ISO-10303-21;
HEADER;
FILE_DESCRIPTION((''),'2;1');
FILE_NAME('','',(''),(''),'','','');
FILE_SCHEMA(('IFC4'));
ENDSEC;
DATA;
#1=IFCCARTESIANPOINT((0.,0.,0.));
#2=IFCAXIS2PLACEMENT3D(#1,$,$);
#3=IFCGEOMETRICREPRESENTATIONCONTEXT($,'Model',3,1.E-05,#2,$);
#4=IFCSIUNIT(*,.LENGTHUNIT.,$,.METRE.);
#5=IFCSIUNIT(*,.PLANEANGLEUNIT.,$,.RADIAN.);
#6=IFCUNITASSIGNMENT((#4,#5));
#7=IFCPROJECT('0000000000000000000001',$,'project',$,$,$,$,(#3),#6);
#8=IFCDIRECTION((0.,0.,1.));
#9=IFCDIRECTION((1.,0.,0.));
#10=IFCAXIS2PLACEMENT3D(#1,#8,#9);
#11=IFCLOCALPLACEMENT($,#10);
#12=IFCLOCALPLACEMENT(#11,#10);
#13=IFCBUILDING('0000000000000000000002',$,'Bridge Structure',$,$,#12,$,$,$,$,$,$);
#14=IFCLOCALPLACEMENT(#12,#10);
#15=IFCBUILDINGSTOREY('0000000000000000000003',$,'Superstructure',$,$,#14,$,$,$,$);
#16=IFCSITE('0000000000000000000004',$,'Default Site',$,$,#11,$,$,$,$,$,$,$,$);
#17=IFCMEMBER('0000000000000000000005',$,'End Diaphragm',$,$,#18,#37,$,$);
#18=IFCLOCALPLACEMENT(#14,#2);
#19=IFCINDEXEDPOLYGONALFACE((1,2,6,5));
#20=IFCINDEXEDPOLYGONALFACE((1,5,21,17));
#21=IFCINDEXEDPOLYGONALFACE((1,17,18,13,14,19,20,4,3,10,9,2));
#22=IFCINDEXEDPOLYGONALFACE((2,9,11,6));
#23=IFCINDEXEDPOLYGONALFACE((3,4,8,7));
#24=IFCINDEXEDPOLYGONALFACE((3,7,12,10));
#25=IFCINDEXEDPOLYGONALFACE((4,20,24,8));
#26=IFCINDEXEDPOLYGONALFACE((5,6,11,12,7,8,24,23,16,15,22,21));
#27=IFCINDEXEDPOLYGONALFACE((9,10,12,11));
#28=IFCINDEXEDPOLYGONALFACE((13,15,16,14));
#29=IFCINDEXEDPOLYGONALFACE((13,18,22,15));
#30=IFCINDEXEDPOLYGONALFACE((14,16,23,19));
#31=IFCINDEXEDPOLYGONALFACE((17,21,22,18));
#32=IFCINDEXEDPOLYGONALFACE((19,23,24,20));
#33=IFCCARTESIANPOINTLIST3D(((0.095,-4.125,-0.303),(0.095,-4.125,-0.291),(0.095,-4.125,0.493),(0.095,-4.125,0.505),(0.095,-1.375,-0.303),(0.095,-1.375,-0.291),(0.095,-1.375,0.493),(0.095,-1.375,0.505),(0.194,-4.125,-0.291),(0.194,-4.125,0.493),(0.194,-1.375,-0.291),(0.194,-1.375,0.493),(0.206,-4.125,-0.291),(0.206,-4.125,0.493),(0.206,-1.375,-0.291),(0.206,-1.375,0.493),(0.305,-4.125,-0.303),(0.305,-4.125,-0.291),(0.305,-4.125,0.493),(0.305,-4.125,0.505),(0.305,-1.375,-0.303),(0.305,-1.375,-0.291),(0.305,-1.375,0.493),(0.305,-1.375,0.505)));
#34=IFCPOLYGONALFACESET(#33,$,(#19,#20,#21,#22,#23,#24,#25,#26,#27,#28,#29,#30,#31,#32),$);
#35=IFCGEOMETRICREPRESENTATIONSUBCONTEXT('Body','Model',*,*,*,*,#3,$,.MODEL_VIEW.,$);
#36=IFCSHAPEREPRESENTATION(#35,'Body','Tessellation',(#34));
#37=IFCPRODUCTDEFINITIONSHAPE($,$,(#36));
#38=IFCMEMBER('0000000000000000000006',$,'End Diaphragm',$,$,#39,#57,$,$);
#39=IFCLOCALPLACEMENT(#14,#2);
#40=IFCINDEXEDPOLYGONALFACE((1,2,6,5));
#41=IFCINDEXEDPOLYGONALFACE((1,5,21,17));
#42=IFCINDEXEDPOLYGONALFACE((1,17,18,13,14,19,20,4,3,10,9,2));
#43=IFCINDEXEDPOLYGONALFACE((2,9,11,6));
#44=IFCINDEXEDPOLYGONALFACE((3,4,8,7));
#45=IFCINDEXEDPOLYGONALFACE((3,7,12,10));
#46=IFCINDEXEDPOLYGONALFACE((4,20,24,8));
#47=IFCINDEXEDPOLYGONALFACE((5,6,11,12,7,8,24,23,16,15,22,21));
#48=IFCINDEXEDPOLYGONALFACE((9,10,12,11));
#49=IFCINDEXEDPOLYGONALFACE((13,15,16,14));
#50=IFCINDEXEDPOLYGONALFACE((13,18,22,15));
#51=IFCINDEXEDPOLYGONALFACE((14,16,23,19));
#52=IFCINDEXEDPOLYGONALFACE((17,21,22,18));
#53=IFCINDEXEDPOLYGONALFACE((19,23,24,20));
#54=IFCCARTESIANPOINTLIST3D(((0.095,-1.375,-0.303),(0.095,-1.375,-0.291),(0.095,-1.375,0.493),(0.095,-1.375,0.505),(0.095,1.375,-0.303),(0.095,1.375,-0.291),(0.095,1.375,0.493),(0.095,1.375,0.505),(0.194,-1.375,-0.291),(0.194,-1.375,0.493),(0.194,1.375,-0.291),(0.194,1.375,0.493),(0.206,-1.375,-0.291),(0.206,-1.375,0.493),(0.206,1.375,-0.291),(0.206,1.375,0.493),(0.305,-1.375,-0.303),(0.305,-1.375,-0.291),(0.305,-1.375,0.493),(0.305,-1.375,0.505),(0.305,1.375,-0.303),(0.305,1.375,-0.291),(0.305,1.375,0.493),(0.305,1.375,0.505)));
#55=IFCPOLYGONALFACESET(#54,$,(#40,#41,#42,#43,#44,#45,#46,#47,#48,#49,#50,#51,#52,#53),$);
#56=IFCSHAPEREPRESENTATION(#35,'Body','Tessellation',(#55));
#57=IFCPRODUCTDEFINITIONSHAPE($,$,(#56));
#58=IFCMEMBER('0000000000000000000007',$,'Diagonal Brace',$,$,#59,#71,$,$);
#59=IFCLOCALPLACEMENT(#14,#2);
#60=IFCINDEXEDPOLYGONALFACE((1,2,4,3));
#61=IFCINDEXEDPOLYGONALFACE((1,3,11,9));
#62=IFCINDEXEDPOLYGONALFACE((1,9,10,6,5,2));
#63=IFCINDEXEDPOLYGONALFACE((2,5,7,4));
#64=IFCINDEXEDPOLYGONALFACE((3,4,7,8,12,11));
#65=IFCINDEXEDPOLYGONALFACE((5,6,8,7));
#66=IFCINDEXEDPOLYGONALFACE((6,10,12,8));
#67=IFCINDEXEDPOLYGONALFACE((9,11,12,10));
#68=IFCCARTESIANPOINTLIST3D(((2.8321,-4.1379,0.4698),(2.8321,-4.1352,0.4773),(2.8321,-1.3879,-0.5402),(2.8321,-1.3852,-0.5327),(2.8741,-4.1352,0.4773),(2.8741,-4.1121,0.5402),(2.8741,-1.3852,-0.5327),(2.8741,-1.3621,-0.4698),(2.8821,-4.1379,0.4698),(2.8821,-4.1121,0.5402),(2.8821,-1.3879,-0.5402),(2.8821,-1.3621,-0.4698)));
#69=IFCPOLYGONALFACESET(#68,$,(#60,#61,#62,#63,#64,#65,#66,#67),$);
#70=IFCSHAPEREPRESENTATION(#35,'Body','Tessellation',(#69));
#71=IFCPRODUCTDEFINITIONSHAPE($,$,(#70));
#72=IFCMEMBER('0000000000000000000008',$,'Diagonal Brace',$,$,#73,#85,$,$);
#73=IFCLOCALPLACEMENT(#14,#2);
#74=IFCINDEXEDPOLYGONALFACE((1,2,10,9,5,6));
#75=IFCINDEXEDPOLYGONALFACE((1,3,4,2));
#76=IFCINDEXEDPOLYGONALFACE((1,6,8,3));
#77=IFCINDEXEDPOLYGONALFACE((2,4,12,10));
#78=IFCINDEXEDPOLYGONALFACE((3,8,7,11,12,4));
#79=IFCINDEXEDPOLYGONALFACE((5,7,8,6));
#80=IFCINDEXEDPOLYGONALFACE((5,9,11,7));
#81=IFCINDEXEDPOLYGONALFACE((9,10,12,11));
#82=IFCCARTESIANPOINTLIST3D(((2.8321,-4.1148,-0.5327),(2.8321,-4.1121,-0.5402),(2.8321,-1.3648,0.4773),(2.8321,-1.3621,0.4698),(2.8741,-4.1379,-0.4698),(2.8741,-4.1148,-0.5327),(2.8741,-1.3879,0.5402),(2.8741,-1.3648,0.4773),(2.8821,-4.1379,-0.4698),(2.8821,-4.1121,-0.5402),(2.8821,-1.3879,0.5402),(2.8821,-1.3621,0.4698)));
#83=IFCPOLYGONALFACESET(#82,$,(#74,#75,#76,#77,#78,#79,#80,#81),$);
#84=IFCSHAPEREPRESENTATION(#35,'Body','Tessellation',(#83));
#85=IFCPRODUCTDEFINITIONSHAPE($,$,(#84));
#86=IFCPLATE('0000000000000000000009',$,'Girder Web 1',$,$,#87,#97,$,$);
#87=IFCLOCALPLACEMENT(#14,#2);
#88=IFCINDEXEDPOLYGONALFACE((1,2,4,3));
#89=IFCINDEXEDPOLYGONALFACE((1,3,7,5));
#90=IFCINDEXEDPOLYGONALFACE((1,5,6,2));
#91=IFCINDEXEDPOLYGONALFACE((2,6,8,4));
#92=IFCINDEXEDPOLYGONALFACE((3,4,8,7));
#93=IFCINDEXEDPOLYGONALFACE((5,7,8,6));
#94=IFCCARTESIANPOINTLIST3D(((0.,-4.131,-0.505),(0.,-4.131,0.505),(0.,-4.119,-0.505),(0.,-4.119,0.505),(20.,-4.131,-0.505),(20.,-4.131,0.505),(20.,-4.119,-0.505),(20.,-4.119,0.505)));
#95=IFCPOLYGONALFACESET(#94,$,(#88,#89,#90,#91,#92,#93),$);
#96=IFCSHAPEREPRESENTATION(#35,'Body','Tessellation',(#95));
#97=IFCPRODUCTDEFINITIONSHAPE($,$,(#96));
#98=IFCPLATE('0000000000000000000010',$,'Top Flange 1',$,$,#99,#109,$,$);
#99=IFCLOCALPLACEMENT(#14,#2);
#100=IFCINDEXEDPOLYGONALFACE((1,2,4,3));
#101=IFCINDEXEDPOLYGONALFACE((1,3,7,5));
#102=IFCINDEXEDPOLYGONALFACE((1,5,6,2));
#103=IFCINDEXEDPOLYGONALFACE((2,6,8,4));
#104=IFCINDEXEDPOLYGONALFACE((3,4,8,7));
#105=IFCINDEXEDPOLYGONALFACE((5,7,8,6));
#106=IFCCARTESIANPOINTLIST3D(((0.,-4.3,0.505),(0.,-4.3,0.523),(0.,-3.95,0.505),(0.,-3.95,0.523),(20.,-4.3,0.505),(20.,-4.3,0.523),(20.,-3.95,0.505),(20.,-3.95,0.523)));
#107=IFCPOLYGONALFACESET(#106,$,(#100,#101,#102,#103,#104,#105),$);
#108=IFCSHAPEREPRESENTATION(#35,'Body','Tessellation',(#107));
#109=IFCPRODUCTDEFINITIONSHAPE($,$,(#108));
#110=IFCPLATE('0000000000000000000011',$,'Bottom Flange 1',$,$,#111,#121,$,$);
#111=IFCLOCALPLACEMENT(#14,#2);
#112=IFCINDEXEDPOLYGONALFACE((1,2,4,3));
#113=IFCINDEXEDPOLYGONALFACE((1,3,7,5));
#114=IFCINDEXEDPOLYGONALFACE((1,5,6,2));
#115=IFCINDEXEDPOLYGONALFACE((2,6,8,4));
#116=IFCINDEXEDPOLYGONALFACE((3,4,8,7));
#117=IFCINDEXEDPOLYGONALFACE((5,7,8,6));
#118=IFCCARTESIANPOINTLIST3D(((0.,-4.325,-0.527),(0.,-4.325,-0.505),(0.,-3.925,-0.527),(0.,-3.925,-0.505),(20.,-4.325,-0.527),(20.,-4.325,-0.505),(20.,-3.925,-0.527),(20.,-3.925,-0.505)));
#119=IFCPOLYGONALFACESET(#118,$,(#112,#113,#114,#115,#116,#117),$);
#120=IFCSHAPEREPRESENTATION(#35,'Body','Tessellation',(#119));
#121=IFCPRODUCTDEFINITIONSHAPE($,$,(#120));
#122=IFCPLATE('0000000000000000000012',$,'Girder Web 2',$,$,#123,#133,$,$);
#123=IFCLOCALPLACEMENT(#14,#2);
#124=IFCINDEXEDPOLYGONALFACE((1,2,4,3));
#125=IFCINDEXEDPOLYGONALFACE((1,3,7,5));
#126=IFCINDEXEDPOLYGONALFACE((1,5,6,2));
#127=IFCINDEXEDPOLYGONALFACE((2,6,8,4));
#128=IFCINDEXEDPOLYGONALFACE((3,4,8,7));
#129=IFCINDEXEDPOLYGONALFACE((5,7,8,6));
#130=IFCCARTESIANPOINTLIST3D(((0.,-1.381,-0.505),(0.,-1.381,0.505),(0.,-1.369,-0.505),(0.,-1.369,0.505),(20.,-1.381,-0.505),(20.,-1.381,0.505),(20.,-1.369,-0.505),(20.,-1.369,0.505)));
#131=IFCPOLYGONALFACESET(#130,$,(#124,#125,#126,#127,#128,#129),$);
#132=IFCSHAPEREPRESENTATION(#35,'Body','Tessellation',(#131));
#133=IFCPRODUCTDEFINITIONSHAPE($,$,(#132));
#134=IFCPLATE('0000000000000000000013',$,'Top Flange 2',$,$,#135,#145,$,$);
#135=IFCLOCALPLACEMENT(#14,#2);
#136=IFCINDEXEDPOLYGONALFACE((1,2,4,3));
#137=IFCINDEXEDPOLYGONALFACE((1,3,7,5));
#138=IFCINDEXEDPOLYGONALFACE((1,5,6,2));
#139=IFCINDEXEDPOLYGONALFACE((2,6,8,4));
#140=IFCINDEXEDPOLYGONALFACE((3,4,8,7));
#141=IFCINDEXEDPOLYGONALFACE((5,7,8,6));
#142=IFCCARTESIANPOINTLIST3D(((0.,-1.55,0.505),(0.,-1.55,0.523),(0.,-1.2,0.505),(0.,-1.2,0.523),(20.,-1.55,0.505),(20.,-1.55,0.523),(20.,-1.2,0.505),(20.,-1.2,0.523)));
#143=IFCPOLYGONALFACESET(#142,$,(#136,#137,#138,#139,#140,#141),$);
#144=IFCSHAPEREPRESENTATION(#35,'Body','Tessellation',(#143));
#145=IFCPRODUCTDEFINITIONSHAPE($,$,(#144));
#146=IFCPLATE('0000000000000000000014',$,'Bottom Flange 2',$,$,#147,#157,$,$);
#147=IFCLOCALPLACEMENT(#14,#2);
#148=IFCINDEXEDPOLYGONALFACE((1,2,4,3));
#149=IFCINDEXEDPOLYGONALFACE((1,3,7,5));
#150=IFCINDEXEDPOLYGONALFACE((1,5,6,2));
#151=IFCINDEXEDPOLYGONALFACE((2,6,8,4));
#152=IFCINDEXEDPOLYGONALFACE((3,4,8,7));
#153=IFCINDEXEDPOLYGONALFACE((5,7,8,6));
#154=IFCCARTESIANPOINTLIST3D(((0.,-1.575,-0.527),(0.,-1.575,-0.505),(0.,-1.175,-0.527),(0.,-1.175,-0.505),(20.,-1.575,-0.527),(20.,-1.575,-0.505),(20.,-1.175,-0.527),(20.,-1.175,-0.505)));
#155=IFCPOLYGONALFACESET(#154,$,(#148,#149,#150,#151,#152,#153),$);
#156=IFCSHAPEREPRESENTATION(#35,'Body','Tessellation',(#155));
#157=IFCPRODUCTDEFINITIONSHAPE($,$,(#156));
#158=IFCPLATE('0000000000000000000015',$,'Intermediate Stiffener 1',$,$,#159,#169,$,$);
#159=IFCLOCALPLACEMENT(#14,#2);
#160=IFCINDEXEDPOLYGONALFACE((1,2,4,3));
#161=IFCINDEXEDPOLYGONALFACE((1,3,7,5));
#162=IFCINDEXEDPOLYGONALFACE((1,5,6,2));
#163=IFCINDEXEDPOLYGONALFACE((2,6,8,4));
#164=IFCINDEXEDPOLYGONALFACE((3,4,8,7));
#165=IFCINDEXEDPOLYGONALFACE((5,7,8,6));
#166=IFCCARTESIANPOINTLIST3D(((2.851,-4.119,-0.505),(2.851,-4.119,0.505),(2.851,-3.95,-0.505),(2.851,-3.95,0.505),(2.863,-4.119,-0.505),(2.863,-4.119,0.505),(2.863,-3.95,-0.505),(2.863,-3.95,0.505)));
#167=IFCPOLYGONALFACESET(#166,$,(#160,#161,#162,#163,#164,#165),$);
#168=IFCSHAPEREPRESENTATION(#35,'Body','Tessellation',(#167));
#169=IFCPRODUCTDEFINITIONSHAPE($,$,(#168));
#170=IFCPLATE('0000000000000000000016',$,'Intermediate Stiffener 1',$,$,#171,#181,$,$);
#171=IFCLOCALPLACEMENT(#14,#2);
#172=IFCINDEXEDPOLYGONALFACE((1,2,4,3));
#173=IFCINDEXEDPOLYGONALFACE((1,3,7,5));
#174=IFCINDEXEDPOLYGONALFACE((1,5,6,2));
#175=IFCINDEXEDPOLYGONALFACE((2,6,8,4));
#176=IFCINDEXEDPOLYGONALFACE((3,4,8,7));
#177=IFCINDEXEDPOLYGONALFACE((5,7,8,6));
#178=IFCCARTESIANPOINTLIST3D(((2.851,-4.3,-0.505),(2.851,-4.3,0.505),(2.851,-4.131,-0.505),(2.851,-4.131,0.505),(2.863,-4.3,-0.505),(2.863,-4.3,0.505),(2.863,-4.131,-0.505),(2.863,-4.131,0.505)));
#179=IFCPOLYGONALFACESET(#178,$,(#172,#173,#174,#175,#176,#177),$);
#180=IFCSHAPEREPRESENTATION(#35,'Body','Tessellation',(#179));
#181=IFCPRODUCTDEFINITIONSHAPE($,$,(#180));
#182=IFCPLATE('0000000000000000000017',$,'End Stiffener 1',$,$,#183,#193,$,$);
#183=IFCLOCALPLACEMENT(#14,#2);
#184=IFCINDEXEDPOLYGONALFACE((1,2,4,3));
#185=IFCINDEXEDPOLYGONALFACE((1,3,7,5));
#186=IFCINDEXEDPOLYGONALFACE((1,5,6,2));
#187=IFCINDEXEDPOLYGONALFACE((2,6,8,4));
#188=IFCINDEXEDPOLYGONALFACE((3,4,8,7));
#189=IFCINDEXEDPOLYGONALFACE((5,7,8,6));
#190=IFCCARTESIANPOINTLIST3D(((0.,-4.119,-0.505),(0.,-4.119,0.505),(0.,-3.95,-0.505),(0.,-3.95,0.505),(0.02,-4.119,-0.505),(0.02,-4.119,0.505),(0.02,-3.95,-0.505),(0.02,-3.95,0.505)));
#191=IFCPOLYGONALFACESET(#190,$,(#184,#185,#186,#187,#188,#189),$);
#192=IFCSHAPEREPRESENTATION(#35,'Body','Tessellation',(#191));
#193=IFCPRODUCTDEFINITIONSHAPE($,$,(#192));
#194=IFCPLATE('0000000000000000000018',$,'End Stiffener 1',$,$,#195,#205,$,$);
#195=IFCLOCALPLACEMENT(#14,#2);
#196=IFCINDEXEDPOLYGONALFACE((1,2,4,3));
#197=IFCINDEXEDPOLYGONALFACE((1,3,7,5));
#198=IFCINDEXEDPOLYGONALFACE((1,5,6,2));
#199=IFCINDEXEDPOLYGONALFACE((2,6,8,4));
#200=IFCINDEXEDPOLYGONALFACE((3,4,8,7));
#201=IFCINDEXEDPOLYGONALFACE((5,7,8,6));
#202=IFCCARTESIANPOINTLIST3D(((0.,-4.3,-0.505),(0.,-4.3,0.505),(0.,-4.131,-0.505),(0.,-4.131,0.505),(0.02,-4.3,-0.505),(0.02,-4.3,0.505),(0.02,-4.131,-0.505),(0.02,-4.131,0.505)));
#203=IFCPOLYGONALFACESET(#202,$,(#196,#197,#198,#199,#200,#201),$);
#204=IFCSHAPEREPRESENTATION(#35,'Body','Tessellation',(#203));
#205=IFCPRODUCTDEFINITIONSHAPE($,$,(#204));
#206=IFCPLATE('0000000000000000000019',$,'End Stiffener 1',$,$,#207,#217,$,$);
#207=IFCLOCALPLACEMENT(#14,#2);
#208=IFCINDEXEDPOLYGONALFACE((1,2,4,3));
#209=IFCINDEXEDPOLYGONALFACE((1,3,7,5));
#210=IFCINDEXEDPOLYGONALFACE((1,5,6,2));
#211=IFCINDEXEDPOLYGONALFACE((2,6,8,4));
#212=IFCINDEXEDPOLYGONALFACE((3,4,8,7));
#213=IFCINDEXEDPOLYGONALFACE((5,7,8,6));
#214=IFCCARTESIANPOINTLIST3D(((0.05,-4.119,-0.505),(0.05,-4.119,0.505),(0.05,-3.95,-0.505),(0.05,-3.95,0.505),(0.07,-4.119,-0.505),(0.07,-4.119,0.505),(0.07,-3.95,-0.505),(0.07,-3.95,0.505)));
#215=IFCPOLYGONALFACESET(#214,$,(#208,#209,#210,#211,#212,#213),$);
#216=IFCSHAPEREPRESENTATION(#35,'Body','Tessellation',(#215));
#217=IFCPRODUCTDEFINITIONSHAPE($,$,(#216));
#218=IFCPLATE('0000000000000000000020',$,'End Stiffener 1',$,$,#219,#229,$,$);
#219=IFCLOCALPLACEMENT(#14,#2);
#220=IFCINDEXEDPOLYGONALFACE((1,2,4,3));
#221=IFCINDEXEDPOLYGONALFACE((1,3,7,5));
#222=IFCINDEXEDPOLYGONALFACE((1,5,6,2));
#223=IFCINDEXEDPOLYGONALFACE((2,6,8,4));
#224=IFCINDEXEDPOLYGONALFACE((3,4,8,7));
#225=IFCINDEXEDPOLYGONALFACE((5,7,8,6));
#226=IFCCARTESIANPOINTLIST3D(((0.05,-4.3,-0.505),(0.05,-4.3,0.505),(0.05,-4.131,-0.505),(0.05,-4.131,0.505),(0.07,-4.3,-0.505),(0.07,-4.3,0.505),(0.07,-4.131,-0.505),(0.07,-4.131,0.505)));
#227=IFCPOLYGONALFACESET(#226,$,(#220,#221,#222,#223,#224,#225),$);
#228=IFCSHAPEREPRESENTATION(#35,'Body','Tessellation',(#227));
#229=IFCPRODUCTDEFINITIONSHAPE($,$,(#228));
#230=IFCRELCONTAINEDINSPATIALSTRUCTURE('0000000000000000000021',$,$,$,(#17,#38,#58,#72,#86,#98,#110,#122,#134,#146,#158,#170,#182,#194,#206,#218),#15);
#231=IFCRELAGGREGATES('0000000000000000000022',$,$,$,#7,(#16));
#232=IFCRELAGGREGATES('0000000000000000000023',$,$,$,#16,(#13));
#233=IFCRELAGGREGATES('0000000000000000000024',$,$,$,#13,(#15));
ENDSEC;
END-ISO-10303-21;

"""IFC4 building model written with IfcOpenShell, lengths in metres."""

from ifc_helpers import new_model, si_unit, frame, origin, origin_with_axes, origin_2d_with_axis, place, context, subcontext, project, spatial, rectangle, i_section, l_section, extrude, element, save


model = new_model("IFC4")

# Units and contexts
model_context = context("Model", 3, precision=1e-05, world=origin())
body_context = subcontext(model_context, "Body", "Model", "MODEL_VIEW")
ifc_project = project(units=[si_unit("LENGTHUNIT", "METRE"), si_unit("PLANEANGLEUNIT", "RADIAN")], contexts=[model_context])

# Site, building, storey
site_placement = place(None, origin_with_axes())
site = spatial("IfcSite", under=ifc_project, at=site_placement, Name="Default Site")
building_placement = place(site_placement, origin_with_axes())
building = spatial("IfcBuilding", under=site, at=building_placement, Name="Bridge Structure")
storey_placement = place(building_placement, origin_with_axes())
storey = spatial("IfcBuildingStorey", under=building, at=storey_placement, Name="Superstructure")

# Members
for number, where, z_axis, x_axis, name in (
    (1, (0.2, -4.125, 0.101), (0.0, 1.0, 0.0), (-1.0, 0.0, 0.0), "End Diaphragm"),
    (2, (0.2, -1.375, 0.101), (0.0, 1.0, 0.0), (-1.0, 0.0, 0.0), "End Diaphragm"),
):
    element("IfcMember", number, at=place(storey_placement, frame(where, z_axis=z_axis, x_axis=x_axis)), inside=storey, Name=name, context=body_context, shape_type="SweptSolid", body=[
        extrude(i_section(OverallWidth=0.21, OverallDepth=0.808, WebThickness=0.012, FlangeThickness=0.012, at=origin_2d_with_axis()), origin_with_axes(), (0.0, 0.0, 1.0), 2.75),
    ])
for number, where, z_axis, x_axis, name in (
    (3, (2.8571, -4.125, 0.505), (0.0, 0.938692, -0.344756), (-1.0, 0.0, 0.0), "Diagonal Brace"),
    (4, (2.8571, -4.125, -0.505), (0.0, 0.938692, 0.344756), (-1.0, 0.0, 0.0), "Diagonal Brace"),
):
    element("IfcMember", number, at=place(storey_placement, frame(where, z_axis=z_axis, x_axis=x_axis)), inside=storey, Name=name, context=body_context, shape_type="SweptSolid", body=[
        extrude(l_section(Depth=0.075, Width=0.05, Thickness=0.008, at=origin_2d_with_axis()), origin_with_axes(), (0.0, 0.0, 1.0), 2.9296),
    ])

# Plates
plate_1_placement = place(storey_placement, frame((0.0, -4.125, 0.0), z_axis=(1.0, 0.0, 0.0), x_axis=(0.0, 1.0, 0.0)))
element("IfcPlate", 5, at=plate_1_placement, inside=storey, Name="Girder Web 1", context=body_context, shape_type="SweptSolid", body=[
    extrude(rectangle(XDim=0.012, YDim=1.01, at=origin_2d_with_axis()), origin_with_axes(), (0.0, 0.0, 1.0), 20.0),
])
plate_2_placement = place(storey_placement, frame((0.0, -4.125, 0.514), z_axis=(1.0, 0.0, 0.0), x_axis=(0.0, 1.0, 0.0)))
element("IfcPlate", 6, at=plate_2_placement, inside=storey, Name="Top Flange 1", context=body_context, shape_type="SweptSolid", body=[
    extrude(rectangle(XDim=0.35, YDim=0.018, at=origin_2d_with_axis()), origin_with_axes(), (0.0, 0.0, 1.0), 20.0),
])
plate_3_placement = place(storey_placement, frame((0.0, -4.125, -0.516), z_axis=(1.0, 0.0, 0.0), x_axis=(0.0, 1.0, 0.0)))
element("IfcPlate", 7, at=plate_3_placement, inside=storey, Name="Bottom Flange 1", context=body_context, shape_type="SweptSolid", body=[
    extrude(rectangle(XDim=0.4, YDim=0.022, at=origin_2d_with_axis()), origin_with_axes(), (0.0, 0.0, 1.0), 20.0),
])
plate_4_placement = place(storey_placement, frame((0.0, -1.375, 0.0), z_axis=(1.0, 0.0, 0.0), x_axis=(0.0, 1.0, 0.0)))
element("IfcPlate", 8, at=plate_4_placement, inside=storey, Name="Girder Web 2", context=body_context, shape_type="SweptSolid", body=[
    extrude(rectangle(XDim=0.012, YDim=1.01, at=origin_2d_with_axis()), origin_with_axes(), (0.0, 0.0, 1.0), 20.0),
])
plate_5_placement = place(storey_placement, frame((0.0, -1.375, 0.514), z_axis=(1.0, 0.0, 0.0), x_axis=(0.0, 1.0, 0.0)))
element("IfcPlate", 9, at=plate_5_placement, inside=storey, Name="Top Flange 2", context=body_context, shape_type="SweptSolid", body=[
    extrude(rectangle(XDim=0.35, YDim=0.018, at=origin_2d_with_axis()), origin_with_axes(), (0.0, 0.0, 1.0), 20.0),
])
plate_6_placement = place(storey_placement, frame((0.0, -1.375, -0.516), z_axis=(1.0, 0.0, 0.0), x_axis=(0.0, 1.0, 0.0)))
element("IfcPlate", 10, at=plate_6_placement, inside=storey, Name="Bottom Flange 2", context=body_context, shape_type="SweptSolid", body=[
    extrude(rectangle(XDim=0.4, YDim=0.022, at=origin_2d_with_axis()), origin_with_axes(), (0.0, 0.0, 1.0), 20.0),
])
for number, where, z_axis, x_axis, name in (
    (11, (2.857, -4.0345, -0.505), (0.0, 0.0, 1.0), (1.0, 0.0, 0.0), "Intermediate Stiffener 1"),
    (12, (2.857, -4.2155, -0.505), (0.0, 0.0, 1.0), (1.0, 0.0, 0.0), "Intermediate Stiffener 1"),
):
    element("IfcPlate", number, at=place(storey_placement, frame(where, z_axis=z_axis, x_axis=x_axis)), inside=storey, Name=name, context=body_context, shape_type="SweptSolid", body=[
        extrude(rectangle(XDim=0.012, YDim=0.169, at=origin_2d_with_axis()), origin_with_axes(), (0.0, 0.0, 1.0), 1.01),
    ])
for number, where, z_axis, x_axis, name in (
    (13, (0.01, -4.0345, -0.505), (0.0, 0.0, 1.0), (1.0, 0.0, 0.0), "End Stiffener 1"),
    (14, (0.01, -4.2155, -0.505), (0.0, 0.0, 1.0), (1.0, 0.0, 0.0), "End Stiffener 1"),
    (15, (0.06, -4.0345, -0.505), (0.0, 0.0, 1.0), (1.0, 0.0, 0.0), "End Stiffener 1"),
    (16, (0.06, -4.2155, -0.505), (0.0, 0.0, 1.0), (1.0, 0.0, 0.0), "End Stiffener 1"),
):
    element("IfcPlate", number, at=place(storey_placement, frame(where, z_axis=z_axis, x_axis=x_axis)), inside=storey, Name=name, context=body_context, shape_type="SweptSolid", body=[
        extrude(rectangle(XDim=0.02, YDim=0.169, at=origin_2d_with_axis()), origin_with_axes(), (0.0, 0.0, 1.0), 1.01),
    ])

save(model, "model.ifc")
